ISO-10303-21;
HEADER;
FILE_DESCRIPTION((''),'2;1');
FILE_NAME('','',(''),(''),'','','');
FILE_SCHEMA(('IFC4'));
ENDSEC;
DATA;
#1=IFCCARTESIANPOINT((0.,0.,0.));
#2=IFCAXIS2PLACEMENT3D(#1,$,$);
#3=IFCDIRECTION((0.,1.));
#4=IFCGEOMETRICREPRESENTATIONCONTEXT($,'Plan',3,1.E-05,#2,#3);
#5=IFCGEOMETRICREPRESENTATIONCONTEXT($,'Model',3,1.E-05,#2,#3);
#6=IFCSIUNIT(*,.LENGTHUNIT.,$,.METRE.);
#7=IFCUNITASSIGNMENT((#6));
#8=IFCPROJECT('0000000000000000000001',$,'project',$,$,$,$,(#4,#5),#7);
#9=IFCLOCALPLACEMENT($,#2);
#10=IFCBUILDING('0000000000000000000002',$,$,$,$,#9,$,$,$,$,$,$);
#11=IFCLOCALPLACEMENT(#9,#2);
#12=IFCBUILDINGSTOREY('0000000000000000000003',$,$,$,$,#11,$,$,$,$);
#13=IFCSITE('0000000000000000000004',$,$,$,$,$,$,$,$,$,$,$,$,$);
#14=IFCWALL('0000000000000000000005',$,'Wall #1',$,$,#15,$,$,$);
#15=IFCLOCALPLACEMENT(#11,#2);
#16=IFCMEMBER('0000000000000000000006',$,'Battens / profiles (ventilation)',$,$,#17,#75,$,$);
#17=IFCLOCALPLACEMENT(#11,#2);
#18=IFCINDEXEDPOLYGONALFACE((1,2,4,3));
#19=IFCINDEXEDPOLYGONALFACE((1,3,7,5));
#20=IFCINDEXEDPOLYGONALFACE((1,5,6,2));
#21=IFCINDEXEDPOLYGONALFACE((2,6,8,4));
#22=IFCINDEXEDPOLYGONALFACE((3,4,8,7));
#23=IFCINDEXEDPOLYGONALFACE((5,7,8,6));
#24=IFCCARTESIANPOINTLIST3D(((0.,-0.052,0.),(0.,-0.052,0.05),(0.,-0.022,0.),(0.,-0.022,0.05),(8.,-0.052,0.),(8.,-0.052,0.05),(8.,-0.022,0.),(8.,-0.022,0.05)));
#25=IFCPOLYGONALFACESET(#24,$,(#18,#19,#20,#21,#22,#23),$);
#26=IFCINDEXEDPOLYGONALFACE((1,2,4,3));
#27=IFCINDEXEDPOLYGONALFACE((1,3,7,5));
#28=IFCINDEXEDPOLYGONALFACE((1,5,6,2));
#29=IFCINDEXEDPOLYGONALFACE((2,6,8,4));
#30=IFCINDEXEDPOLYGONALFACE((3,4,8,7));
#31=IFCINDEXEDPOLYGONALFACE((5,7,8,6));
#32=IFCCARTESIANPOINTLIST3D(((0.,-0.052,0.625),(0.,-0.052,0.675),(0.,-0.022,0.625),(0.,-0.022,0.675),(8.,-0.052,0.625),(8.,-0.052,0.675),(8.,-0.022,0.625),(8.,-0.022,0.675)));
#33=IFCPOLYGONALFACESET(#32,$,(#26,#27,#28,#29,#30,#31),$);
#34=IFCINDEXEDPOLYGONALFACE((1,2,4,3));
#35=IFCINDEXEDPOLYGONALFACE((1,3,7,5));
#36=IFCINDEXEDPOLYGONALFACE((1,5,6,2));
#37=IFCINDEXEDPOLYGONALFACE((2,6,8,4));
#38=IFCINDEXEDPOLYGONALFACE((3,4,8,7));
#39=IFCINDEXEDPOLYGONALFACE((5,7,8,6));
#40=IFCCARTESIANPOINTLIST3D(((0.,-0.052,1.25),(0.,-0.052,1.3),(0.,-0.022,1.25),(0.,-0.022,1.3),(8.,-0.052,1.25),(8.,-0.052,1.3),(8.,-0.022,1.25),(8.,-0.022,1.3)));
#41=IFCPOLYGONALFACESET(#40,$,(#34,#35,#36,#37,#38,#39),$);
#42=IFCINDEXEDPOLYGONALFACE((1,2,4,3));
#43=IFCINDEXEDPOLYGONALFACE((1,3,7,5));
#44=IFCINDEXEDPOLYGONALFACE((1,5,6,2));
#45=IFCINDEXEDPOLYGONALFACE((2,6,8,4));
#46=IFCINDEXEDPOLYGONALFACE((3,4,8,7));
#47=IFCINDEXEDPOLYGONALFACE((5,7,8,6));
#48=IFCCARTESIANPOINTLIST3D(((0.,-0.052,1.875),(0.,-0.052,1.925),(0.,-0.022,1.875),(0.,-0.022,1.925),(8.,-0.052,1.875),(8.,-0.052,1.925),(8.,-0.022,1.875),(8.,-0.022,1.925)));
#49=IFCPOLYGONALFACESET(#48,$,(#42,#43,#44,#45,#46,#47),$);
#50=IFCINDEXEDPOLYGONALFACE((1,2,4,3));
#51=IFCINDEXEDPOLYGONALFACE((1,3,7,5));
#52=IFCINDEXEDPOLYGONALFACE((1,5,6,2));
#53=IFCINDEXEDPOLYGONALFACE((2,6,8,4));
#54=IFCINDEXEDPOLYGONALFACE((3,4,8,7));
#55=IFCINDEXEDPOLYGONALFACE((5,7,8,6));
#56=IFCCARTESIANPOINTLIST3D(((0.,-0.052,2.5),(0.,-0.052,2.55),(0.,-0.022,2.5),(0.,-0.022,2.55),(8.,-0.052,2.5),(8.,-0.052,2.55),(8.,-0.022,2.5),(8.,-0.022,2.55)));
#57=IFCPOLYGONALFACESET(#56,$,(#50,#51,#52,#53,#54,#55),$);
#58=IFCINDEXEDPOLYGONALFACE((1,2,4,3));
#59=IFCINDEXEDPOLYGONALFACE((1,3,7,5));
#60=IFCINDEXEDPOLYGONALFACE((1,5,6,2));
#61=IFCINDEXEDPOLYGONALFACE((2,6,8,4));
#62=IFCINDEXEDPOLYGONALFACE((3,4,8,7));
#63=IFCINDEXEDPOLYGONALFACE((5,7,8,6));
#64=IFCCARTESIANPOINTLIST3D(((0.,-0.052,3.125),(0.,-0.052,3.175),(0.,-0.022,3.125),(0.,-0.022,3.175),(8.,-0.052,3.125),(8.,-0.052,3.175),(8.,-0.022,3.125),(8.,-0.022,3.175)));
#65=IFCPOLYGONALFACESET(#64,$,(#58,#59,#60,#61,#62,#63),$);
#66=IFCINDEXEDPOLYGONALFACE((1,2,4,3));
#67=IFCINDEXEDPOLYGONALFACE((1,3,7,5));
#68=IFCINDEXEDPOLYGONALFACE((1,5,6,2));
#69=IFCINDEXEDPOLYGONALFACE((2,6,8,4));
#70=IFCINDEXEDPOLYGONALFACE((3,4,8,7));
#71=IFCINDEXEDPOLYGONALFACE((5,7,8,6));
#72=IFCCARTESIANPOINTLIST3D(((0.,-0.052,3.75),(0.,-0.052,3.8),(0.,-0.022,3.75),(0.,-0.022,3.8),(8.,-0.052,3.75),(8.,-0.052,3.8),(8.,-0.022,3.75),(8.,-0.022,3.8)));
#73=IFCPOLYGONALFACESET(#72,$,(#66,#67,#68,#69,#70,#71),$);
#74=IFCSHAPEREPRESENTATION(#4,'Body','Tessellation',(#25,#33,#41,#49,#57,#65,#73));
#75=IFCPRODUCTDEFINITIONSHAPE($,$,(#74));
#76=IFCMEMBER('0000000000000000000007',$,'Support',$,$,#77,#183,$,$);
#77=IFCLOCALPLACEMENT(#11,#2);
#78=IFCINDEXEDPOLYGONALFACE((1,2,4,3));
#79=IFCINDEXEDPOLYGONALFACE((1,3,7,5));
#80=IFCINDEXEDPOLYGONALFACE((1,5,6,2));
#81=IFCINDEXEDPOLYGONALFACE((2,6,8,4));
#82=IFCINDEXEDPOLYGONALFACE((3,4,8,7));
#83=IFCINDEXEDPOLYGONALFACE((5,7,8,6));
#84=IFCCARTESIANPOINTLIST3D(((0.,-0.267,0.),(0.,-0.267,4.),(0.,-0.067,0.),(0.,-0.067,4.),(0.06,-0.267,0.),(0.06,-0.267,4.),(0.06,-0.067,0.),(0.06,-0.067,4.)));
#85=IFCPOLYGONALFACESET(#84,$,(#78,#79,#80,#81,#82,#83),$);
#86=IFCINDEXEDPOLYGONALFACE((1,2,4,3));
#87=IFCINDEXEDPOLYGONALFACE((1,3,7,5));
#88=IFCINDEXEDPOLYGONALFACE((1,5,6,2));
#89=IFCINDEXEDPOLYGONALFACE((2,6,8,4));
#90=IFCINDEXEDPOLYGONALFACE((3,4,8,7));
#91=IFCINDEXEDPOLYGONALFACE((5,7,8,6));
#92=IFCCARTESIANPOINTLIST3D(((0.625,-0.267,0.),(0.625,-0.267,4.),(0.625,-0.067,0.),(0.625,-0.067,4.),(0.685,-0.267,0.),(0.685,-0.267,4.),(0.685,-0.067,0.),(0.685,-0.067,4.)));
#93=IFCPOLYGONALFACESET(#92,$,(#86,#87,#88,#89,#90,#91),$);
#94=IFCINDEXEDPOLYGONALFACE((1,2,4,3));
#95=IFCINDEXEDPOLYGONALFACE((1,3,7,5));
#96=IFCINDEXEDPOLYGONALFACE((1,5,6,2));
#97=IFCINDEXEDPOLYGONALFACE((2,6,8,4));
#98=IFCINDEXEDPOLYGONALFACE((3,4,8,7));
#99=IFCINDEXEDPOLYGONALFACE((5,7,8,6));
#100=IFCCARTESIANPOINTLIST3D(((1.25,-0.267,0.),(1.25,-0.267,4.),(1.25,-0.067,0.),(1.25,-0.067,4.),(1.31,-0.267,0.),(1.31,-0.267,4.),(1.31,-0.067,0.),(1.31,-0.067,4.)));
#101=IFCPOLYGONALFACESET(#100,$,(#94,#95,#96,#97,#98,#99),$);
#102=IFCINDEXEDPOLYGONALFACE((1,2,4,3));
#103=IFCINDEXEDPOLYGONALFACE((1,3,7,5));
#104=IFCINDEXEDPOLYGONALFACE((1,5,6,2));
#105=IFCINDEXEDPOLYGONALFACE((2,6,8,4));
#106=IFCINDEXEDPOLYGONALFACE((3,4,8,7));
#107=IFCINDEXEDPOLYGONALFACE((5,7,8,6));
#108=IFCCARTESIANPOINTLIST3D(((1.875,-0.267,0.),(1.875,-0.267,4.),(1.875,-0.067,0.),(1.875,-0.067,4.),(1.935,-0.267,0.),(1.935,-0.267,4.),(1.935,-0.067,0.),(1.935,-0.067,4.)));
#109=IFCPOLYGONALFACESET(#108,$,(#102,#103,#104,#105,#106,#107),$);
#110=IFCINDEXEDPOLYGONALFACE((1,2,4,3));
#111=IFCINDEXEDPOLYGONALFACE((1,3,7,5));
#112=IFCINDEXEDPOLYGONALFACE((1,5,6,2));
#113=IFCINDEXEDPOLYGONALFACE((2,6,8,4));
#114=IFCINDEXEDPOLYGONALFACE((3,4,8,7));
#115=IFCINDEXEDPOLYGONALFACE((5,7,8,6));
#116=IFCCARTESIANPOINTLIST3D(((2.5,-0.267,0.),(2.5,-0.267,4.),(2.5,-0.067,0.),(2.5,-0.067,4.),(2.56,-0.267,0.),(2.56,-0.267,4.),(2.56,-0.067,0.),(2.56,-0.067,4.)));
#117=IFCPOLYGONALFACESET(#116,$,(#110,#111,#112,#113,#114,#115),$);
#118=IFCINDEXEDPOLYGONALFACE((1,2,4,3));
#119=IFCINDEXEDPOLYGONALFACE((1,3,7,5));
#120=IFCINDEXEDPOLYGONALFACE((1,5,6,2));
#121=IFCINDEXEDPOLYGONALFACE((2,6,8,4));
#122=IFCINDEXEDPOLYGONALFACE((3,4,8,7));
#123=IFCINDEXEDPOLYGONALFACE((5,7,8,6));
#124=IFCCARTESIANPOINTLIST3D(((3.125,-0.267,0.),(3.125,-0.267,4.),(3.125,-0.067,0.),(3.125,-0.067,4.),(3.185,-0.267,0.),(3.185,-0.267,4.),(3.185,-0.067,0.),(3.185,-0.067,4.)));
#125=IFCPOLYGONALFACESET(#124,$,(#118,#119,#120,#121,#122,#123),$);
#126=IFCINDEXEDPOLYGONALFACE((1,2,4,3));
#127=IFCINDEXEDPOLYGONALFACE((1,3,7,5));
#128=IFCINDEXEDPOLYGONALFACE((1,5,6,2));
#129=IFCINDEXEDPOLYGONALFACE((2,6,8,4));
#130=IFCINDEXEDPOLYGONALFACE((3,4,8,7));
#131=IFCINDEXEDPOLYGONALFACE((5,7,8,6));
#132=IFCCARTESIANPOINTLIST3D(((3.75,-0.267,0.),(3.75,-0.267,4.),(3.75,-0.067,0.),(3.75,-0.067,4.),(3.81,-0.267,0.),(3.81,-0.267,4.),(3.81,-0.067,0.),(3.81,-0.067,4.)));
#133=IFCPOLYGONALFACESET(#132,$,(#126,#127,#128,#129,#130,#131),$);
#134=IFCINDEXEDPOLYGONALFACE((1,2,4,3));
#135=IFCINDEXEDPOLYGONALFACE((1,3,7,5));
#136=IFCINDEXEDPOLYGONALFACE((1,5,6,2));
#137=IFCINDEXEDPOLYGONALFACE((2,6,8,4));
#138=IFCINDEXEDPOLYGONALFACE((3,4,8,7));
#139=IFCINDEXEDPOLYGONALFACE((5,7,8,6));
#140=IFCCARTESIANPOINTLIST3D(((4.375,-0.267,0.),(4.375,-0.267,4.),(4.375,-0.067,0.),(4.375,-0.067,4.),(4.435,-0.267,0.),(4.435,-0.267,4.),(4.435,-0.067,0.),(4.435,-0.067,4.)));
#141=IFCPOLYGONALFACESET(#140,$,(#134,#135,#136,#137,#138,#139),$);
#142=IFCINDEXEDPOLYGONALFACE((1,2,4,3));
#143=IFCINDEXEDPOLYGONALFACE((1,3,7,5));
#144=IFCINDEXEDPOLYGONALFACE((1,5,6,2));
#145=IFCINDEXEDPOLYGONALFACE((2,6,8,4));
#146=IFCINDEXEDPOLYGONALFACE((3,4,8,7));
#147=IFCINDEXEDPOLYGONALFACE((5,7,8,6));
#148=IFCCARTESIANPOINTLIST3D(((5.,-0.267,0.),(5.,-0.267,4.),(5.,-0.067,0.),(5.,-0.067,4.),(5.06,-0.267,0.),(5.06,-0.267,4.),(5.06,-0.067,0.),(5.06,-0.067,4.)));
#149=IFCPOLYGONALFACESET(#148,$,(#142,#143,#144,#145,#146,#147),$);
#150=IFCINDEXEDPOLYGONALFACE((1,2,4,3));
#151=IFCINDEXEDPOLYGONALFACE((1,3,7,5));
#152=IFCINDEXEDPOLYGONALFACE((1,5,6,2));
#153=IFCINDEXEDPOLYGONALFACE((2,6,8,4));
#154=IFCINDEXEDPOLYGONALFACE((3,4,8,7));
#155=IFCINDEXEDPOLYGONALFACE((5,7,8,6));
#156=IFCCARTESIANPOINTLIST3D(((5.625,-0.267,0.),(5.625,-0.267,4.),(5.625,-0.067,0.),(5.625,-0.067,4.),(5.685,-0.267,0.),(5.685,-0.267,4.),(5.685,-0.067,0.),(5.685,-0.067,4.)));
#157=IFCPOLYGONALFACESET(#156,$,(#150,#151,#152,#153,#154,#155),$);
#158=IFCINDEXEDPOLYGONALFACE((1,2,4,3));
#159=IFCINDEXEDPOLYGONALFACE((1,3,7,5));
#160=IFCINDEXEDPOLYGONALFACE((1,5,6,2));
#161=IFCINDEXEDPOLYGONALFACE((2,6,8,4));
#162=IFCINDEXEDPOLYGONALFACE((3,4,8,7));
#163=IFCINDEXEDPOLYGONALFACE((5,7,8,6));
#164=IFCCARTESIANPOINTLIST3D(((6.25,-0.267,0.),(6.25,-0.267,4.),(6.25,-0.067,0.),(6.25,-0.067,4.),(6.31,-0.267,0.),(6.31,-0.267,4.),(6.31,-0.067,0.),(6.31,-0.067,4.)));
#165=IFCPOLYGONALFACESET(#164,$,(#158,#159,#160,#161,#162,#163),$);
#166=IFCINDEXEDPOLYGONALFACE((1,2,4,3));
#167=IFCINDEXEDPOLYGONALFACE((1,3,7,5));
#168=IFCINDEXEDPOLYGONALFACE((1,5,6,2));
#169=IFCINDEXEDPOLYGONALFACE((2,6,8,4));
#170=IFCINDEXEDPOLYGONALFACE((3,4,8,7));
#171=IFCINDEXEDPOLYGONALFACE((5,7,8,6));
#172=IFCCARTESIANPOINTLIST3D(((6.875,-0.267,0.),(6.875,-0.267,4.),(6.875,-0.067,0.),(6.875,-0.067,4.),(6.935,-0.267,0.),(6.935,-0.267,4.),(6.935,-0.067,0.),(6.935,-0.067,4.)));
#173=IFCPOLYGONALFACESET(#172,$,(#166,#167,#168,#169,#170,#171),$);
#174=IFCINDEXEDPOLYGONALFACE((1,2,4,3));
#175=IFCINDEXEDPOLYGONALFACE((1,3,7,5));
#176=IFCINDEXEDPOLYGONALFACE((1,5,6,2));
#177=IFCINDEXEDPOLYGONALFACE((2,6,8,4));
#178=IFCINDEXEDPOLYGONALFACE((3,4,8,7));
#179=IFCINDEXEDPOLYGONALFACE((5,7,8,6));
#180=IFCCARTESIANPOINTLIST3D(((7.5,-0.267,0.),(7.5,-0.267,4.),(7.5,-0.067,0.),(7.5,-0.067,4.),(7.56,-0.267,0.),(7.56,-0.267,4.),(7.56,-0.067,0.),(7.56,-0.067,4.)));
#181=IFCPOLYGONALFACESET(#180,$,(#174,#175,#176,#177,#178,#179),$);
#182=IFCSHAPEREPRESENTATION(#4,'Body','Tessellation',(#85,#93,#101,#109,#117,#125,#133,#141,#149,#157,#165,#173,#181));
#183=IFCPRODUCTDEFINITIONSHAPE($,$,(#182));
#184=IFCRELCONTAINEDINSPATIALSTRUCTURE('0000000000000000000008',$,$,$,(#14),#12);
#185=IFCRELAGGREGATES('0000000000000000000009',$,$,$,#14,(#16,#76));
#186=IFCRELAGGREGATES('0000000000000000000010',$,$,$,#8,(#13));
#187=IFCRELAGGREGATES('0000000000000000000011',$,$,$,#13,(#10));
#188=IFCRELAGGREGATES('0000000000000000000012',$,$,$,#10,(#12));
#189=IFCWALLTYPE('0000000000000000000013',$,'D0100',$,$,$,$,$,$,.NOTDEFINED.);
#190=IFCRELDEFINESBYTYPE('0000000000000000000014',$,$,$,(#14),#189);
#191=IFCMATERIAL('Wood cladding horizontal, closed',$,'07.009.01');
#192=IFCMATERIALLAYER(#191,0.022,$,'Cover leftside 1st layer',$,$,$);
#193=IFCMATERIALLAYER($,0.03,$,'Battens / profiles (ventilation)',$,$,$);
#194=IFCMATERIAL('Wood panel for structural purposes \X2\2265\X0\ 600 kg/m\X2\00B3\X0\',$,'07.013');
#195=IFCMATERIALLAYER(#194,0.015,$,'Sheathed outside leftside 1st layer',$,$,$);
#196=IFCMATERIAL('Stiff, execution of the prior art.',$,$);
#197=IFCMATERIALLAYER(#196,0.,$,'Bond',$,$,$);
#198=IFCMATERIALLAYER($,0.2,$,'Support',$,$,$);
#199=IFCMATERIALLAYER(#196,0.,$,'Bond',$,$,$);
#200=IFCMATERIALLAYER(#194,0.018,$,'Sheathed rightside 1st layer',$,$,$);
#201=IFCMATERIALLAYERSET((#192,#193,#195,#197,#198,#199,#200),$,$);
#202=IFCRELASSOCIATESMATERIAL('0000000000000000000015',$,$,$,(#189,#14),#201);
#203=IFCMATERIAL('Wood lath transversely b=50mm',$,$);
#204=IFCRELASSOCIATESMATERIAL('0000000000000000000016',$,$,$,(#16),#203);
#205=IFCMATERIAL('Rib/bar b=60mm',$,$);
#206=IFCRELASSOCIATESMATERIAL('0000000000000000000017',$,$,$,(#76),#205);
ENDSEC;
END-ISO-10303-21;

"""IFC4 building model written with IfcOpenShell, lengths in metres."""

from ifc_helpers import new_model, si_unit, direction, frame, frame_2d, origin, place, context, project, spatial, rectangle, extrude, material, layer, layer_set, type_object, element, aggregate, save


model = new_model("IFC4")

# Units and contexts
plan_context = context("Plan", 3, precision=1e-05, world=origin(), true_north=direction((0.0, 1.0)))
model_context = context("Model", 3, precision=1e-05, world=origin(), true_north=direction((0.0, 1.0)))
ifc_project = project(units=[si_unit("LENGTHUNIT", "METRE")], contexts=[plan_context, model_context])

# Site, building, storey
site = spatial("IfcSite", under=ifc_project)
building_placement = place(None, origin())
building = spatial("IfcBuilding", under=site, at=building_placement)
storey_placement = place(building_placement, origin())
storey = spatial("IfcBuildingStorey", under=building, at=storey_placement)

# Wall, members
ifc_material_1 = material(Name="Wood cladding horizontal, closed", Category="07.009.01")
ifc_layer_1 = layer(ifc_material_1, 0.022, Name="Cover leftside 1st layer")
ifc_layer_2 = layer(None, 0.03, Name="Battens / profiles (ventilation)")
ifc_material_2 = material(Name="Wood panel for structural purposes ≥ 600 kg/m³", Category="07.013")
ifc_layer_3 = layer(ifc_material_2, 0.015, Name="Sheathed outside leftside 1st layer")
ifc_material_3 = material(Name="Stiff, execution of the prior art.")
ifc_layer_4 = layer(ifc_material_3, 0.0, Name="Bond")
ifc_layer_5 = layer(None, 0.2, Name="Support")
ifc_layer_6 = layer(ifc_material_3, 0.0, Name="Bond")
ifc_layer_7 = layer(ifc_material_2, 0.018, Name="Sheathed rightside 1st layer")
ifc_layer_set = layer_set([ifc_layer_1, ifc_layer_2, ifc_layer_3, ifc_layer_4, ifc_layer_5, ifc_layer_6, ifc_layer_7])
wall_type = type_object("IfcWallType", Name="D0100", PredefinedType="NOTDEFINED", material=ifc_layer_set)
wall_placement = place(None, frame((0.0, 0.0, 0.0), z_axis=(0.0, -1.0, 0.0), x_axis=(1.0, 0.0, 0.0)))
wall = element("IfcWall", 1, at=wall_placement, inside=storey, type_object=wall_type, material=ifc_layer_set, Name="Wall #1")
ifc_material_4 = material(Name="Wood lath transversely b=50mm")
member_1_placement = place(wall_placement, origin())
member_1 = element("IfcMember", 2, at=member_1_placement, material=ifc_material_4, Name="Battens / profiles (ventilation)", context=plan_context, shape_type="SweptSolid", body=[
    extrude(rectangle(XDim=0.05, YDim=0.03, at=frame_2d((0.025, 0.015), x_axis=(1.0, 0.0))), frame((0.0, 0.0, 0.022), z_axis=(1.0, 0.0, 0.0), x_axis=(0.0, 1.0, 0.0)), (0.0, 0.0, 1.0), 8.0),
    extrude(rectangle(XDim=0.05, YDim=0.03, at=frame_2d((0.025, 0.015), x_axis=(1.0, 0.0))), frame((0.0, 0.625, 0.022), z_axis=(1.0, 0.0, 0.0), x_axis=(0.0, 1.0, 0.0)), (0.0, 0.0, 1.0), 8.0),
    extrude(rectangle(XDim=0.05, YDim=0.03, at=frame_2d((0.025, 0.015), x_axis=(1.0, 0.0))), frame((0.0, 1.25, 0.022), z_axis=(1.0, 0.0, 0.0), x_axis=(0.0, 1.0, 0.0)), (0.0, 0.0, 1.0), 8.0),
    extrude(rectangle(XDim=0.05, YDim=0.03, at=frame_2d((0.025, 0.015), x_axis=(1.0, 0.0))), frame((0.0, 1.875, 0.022), z_axis=(1.0, 0.0, 0.0), x_axis=(0.0, 1.0, 0.0)), (0.0, 0.0, 1.0), 8.0),
    extrude(rectangle(XDim=0.05, YDim=0.03, at=frame_2d((0.025, 0.015), x_axis=(1.0, 0.0))), frame((0.0, 2.5, 0.022), z_axis=(1.0, 0.0, 0.0), x_axis=(0.0, 1.0, 0.0)), (0.0, 0.0, 1.0), 8.0),
    extrude(rectangle(XDim=0.05, YDim=0.03, at=frame_2d((0.025, 0.015), x_axis=(1.0, 0.0))), frame((0.0, 3.125, 0.022), z_axis=(1.0, 0.0, 0.0), x_axis=(0.0, 1.0, 0.0)), (0.0, 0.0, 1.0), 8.0),
    extrude(rectangle(XDim=0.05, YDim=0.03, at=frame_2d((0.025, 0.015), x_axis=(1.0, 0.0))), frame((0.0, 3.75, 0.022), z_axis=(1.0, 0.0, 0.0), x_axis=(0.0, 1.0, 0.0)), (0.0, 0.0, 1.0), 8.0),
])
ifc_material_5 = material(Name="Rib/bar b=60mm")
member_2_placement = place(wall_placement, origin())
member_2 = element("IfcMember", 3, at=member_2_placement, material=ifc_material_5, Name="Support", context=plan_context, shape_type="SweptSolid", body=[
    extrude(rectangle(XDim=0.06, YDim=0.2, at=frame_2d((0.03, 0.1), x_axis=(1.0, 0.0))), frame((0.0, 4.0, 0.067), z_axis=(0.0, -1.0, 0.0), x_axis=(1.0, 0.0, 0.0)), (0.0, 0.0, 1.0), 4.0),
    extrude(rectangle(XDim=0.06, YDim=0.2, at=frame_2d((0.03, 0.1), x_axis=(1.0, 0.0))), frame((0.625, 4.0, 0.067), z_axis=(0.0, -1.0, 0.0), x_axis=(1.0, 0.0, 0.0)), (0.0, 0.0, 1.0), 4.0),
    extrude(rectangle(XDim=0.06, YDim=0.2, at=frame_2d((0.03, 0.1), x_axis=(1.0, 0.0))), frame((1.25, 4.0, 0.067), z_axis=(0.0, -1.0, 0.0), x_axis=(1.0, 0.0, 0.0)), (0.0, 0.0, 1.0), 4.0),
    extrude(rectangle(XDim=0.06, YDim=0.2, at=frame_2d((0.03, 0.1), x_axis=(1.0, 0.0))), frame((1.875, 4.0, 0.067), z_axis=(0.0, -1.0, 0.0), x_axis=(1.0, 0.0, 0.0)), (0.0, 0.0, 1.0), 4.0),
    extrude(rectangle(XDim=0.06, YDim=0.2, at=frame_2d((0.03, 0.1), x_axis=(1.0, 0.0))), frame((2.5, 4.0, 0.067), z_axis=(0.0, -1.0, 0.0), x_axis=(1.0, 0.0, 0.0)), (0.0, 0.0, 1.0), 4.0),
    extrude(rectangle(XDim=0.06, YDim=0.2, at=frame_2d((0.03, 0.1), x_axis=(1.0, 0.0))), frame((3.125, 4.0, 0.067), z_axis=(0.0, -1.0, 0.0), x_axis=(1.0, 0.0, 0.0)), (0.0, 0.0, 1.0), 4.0),
    extrude(rectangle(XDim=0.06, YDim=0.2, at=frame_2d((0.03, 0.1), x_axis=(1.0, 0.0))), frame((3.75, 4.0, 0.067), z_axis=(0.0, -1.0, 0.0), x_axis=(1.0, 0.0, 0.0)), (0.0, 0.0, 1.0), 4.0),
    extrude(rectangle(XDim=0.06, YDim=0.2, at=frame_2d((0.03, 0.1), x_axis=(1.0, 0.0))), frame((4.375, 4.0, 0.067), z_axis=(0.0, -1.0, 0.0), x_axis=(1.0, 0.0, 0.0)), (0.0, 0.0, 1.0), 4.0),
    extrude(rectangle(XDim=0.06, YDim=0.2, at=frame_2d((0.03, 0.1), x_axis=(1.0, 0.0))), frame((5.0, 4.0, 0.067), z_axis=(0.0, -1.0, 0.0), x_axis=(1.0, 0.0, 0.0)), (0.0, 0.0, 1.0), 4.0),
    extrude(rectangle(XDim=0.06, YDim=0.2, at=frame_2d((0.03, 0.1), x_axis=(1.0, 0.0))), frame((5.625, 4.0, 0.067), z_axis=(0.0, -1.0, 0.0), x_axis=(1.0, 0.0, 0.0)), (0.0, 0.0, 1.0), 4.0),
    extrude(rectangle(XDim=0.06, YDim=0.2, at=frame_2d((0.03, 0.1), x_axis=(1.0, 0.0))), frame((6.25, 4.0, 0.067), z_axis=(0.0, -1.0, 0.0), x_axis=(1.0, 0.0, 0.0)), (0.0, 0.0, 1.0), 4.0),
    extrude(rectangle(XDim=0.06, YDim=0.2, at=frame_2d((0.03, 0.1), x_axis=(1.0, 0.0))), frame((6.875, 4.0, 0.067), z_axis=(0.0, -1.0, 0.0), x_axis=(1.0, 0.0, 0.0)), (0.0, 0.0, 1.0), 4.0),
    extrude(rectangle(XDim=0.06, YDim=0.2, at=frame_2d((0.03, 0.1), x_axis=(1.0, 0.0))), frame((7.5, 4.0, 0.067), z_axis=(0.0, -1.0, 0.0), x_axis=(1.0, 0.0, 0.0)), (0.0, 0.0, 1.0), 4.0),
])
aggregate(wall, [member_1, member_2])

save(model, "model.ifc")
